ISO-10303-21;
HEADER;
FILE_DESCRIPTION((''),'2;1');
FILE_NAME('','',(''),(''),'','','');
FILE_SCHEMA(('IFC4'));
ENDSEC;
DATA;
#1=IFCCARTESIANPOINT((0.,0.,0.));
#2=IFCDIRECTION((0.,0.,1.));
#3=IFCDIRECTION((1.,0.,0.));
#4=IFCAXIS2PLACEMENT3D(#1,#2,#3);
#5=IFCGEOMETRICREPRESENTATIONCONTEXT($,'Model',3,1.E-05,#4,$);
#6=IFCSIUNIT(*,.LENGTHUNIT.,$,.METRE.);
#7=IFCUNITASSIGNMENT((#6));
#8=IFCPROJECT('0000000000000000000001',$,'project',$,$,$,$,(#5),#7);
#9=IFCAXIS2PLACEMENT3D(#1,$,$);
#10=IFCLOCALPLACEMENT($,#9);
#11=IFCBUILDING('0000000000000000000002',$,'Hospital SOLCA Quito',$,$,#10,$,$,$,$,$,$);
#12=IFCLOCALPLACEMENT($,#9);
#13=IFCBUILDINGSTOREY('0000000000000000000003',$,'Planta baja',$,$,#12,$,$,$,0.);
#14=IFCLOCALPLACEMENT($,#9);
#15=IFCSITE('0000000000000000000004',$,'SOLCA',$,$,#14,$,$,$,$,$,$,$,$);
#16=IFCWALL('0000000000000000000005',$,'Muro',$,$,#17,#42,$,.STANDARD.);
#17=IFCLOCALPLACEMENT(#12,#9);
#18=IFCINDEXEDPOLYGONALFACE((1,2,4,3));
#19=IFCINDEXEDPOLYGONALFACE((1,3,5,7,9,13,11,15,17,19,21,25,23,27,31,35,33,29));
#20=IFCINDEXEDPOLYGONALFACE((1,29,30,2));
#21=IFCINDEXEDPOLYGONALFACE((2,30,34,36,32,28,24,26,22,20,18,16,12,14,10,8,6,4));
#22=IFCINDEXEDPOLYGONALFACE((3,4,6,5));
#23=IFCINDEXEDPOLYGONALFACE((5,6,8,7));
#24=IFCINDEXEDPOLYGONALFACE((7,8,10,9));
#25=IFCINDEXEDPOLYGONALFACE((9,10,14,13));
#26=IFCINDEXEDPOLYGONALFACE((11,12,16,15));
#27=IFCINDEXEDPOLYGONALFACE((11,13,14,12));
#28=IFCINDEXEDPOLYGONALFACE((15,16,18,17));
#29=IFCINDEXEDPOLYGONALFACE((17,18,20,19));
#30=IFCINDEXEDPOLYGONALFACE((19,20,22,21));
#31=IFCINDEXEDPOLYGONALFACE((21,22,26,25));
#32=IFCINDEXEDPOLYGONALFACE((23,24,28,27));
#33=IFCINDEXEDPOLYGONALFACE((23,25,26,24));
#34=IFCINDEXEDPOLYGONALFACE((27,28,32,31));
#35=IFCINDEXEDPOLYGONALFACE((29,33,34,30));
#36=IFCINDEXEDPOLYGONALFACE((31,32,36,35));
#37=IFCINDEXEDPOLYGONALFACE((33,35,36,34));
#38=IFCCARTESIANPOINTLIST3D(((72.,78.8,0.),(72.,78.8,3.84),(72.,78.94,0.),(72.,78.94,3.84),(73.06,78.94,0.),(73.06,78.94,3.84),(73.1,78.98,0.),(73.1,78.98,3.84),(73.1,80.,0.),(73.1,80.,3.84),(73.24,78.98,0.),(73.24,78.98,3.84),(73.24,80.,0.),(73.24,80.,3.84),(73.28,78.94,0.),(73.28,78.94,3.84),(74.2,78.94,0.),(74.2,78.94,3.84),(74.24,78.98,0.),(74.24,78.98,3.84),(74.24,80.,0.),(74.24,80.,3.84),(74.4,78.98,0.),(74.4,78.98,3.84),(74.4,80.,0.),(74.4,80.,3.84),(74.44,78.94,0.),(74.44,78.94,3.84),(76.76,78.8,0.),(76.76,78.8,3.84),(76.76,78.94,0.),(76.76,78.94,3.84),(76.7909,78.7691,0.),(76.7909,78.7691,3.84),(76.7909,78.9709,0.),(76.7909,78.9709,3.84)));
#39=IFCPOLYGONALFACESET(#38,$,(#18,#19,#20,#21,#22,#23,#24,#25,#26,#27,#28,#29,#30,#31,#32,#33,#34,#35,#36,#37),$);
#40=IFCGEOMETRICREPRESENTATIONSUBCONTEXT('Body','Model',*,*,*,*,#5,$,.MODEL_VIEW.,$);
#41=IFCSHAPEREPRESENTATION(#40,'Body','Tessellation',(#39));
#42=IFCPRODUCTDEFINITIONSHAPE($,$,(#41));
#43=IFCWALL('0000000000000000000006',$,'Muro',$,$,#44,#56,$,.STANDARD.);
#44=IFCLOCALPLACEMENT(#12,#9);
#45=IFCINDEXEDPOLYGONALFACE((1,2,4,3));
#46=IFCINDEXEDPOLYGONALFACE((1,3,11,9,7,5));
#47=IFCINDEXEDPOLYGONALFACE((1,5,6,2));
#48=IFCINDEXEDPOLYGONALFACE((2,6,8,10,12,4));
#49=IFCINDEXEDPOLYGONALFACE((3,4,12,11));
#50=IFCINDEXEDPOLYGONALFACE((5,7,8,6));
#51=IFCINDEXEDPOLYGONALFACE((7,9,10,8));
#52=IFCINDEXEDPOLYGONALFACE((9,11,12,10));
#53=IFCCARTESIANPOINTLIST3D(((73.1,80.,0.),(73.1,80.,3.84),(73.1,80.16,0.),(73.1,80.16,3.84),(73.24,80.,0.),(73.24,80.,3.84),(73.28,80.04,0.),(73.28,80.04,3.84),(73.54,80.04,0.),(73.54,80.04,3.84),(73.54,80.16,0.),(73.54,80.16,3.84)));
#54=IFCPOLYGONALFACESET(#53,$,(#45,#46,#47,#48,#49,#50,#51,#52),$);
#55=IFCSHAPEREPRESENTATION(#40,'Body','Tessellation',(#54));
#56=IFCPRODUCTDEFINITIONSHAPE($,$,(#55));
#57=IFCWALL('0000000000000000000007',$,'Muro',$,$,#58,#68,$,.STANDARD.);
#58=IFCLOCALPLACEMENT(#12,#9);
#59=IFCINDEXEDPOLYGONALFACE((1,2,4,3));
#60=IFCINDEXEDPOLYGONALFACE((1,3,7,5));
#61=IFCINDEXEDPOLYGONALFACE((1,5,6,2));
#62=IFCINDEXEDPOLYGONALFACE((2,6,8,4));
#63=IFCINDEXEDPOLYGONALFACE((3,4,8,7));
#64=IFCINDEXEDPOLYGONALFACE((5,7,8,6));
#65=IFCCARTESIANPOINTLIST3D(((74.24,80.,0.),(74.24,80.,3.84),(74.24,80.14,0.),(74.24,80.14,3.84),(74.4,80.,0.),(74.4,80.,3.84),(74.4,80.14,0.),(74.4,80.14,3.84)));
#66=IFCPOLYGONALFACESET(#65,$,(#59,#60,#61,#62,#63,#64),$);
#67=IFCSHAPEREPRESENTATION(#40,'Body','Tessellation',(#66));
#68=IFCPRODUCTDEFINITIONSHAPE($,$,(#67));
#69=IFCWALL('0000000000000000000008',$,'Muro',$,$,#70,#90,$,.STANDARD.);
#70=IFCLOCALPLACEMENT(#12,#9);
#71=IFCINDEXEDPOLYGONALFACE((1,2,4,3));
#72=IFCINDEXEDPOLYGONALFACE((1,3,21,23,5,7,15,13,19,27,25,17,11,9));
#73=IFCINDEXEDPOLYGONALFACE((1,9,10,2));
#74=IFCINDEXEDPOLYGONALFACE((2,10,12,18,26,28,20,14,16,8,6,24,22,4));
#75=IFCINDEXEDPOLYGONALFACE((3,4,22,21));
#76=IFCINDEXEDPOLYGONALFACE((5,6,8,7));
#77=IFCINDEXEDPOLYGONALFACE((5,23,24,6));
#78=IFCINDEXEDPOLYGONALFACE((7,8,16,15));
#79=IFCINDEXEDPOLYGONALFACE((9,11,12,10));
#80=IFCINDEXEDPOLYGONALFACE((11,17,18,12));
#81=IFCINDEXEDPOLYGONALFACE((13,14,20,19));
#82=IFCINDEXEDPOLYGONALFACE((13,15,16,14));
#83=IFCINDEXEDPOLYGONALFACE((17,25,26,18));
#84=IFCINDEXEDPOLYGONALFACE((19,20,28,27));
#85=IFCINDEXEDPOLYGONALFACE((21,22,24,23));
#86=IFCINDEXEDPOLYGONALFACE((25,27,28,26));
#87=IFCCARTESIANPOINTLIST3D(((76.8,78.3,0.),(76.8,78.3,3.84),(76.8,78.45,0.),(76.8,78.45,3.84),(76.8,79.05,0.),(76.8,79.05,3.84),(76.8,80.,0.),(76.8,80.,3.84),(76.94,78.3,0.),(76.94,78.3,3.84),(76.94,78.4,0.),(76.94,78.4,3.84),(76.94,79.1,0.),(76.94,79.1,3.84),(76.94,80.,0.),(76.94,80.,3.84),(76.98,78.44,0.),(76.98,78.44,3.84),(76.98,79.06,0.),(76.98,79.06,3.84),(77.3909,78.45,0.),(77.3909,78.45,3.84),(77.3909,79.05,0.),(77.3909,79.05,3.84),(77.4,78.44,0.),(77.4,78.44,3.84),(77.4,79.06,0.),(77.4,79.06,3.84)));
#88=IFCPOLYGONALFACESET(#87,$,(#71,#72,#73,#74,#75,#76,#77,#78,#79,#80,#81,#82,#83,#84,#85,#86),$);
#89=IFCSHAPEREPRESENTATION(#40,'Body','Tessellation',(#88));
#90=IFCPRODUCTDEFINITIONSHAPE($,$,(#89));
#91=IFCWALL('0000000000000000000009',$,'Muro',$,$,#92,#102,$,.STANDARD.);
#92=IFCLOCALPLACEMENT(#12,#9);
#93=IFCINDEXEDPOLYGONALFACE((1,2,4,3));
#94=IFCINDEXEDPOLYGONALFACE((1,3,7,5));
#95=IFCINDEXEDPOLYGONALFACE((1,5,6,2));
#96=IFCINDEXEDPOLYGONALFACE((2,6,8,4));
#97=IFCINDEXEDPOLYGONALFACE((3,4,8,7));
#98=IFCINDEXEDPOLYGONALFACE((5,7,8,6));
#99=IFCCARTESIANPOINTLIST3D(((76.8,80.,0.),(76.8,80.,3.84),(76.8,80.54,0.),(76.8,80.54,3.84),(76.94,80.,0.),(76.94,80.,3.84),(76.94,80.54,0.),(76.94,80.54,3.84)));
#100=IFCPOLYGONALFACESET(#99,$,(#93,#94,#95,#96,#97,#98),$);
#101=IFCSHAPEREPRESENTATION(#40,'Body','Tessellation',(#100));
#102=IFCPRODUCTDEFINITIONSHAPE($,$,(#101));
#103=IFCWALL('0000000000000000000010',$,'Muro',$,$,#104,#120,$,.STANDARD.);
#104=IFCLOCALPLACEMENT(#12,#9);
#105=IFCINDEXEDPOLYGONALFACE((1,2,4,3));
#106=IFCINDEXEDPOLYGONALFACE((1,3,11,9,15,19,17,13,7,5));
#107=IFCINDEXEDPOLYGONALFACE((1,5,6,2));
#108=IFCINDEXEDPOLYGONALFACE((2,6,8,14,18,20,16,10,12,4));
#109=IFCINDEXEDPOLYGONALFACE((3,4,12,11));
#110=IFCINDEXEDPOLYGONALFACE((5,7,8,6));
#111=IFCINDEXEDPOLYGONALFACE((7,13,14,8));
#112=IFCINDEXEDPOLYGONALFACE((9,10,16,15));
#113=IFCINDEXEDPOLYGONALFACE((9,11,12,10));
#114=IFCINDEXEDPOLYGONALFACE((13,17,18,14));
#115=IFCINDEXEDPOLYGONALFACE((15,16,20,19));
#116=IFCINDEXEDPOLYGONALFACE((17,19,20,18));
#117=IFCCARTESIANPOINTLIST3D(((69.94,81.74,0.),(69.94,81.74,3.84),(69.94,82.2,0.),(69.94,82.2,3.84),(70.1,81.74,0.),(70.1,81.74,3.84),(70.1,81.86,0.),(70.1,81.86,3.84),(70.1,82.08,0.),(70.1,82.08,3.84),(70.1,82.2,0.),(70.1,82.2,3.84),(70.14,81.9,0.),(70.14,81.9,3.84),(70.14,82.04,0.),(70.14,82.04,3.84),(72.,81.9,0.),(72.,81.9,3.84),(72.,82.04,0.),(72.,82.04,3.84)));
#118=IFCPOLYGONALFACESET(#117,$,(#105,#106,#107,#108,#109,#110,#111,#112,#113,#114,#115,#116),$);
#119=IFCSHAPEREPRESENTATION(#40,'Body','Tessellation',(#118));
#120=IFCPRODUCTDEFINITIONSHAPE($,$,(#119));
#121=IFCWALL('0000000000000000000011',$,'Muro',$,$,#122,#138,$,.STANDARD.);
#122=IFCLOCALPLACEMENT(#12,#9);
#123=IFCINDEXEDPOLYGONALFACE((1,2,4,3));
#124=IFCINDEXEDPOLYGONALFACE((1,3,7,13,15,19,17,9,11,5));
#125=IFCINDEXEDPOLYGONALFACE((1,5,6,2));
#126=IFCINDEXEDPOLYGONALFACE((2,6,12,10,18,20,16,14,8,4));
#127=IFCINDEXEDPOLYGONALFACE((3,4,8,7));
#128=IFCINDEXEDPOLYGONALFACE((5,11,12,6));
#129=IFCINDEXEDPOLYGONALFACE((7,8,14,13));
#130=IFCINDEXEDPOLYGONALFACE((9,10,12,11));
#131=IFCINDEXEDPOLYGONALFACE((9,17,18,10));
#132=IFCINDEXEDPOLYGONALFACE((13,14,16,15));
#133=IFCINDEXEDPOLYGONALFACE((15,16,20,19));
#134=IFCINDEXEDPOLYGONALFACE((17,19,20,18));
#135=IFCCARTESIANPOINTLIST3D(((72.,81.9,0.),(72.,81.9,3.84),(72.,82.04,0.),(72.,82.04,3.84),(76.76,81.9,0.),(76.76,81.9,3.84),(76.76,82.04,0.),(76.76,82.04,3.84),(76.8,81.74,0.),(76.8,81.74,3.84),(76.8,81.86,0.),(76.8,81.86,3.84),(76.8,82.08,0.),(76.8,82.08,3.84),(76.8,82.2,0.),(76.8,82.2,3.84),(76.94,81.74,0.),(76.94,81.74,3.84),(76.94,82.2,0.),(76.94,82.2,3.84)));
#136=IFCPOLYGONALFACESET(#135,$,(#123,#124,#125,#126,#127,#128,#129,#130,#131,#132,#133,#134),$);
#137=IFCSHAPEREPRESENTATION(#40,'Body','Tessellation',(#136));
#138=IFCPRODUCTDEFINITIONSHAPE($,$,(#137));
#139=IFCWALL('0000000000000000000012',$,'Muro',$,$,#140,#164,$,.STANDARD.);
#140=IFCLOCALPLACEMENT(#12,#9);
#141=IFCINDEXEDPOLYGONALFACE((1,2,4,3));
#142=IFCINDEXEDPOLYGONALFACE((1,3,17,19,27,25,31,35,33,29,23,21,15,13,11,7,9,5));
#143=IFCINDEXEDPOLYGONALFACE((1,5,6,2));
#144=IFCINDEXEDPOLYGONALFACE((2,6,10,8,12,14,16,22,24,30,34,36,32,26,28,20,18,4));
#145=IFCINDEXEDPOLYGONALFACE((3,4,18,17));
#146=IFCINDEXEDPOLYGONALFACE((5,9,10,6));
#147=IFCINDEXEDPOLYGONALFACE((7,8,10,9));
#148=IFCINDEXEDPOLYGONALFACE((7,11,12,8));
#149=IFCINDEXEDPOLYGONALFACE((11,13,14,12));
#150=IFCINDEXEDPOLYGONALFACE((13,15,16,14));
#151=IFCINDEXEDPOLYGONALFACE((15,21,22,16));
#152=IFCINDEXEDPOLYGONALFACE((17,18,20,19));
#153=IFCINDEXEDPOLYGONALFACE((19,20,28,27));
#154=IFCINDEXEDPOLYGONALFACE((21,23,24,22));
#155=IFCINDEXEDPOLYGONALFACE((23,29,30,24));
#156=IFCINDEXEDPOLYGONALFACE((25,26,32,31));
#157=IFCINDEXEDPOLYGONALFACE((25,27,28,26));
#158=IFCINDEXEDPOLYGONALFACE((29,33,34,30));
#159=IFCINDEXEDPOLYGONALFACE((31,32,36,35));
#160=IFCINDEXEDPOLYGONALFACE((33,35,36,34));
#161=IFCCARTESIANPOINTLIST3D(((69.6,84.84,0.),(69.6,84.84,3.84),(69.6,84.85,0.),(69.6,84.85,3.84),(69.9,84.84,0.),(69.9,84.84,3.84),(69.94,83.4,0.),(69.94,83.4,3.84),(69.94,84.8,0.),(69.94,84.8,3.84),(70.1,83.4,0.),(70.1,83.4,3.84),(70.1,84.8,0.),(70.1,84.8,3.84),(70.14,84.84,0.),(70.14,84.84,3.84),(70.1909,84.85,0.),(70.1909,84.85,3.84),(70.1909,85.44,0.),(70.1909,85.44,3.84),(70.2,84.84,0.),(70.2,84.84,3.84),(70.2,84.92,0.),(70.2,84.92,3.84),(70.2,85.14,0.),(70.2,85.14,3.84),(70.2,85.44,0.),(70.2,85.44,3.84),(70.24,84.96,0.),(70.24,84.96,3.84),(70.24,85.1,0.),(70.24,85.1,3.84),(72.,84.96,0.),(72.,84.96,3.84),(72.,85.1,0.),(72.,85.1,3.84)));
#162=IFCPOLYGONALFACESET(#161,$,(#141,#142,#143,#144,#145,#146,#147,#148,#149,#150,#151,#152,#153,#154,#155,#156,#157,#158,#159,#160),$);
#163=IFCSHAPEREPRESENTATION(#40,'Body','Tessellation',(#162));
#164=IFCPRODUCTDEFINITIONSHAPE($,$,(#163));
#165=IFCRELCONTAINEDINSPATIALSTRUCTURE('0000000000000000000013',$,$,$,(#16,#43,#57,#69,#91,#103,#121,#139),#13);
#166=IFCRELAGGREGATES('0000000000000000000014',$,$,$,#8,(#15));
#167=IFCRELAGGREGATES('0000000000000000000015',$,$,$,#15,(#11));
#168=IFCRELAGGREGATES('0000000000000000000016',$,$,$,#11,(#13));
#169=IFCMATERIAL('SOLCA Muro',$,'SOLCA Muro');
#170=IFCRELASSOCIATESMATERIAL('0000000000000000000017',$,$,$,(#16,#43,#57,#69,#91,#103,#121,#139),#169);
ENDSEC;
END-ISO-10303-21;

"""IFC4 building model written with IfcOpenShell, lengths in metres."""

from ifc_helpers import new_model, si_unit, origin, origin_with_axes, place, context, subcontext, project, spatial, polyline, outline, extrude, material, element, save


model = new_model("IFC4")

# Units and contexts
model_context = context("Model", 3, precision=1e-05, world=origin_with_axes())
body_context = subcontext(model_context, "Body", "Model", "MODEL_VIEW")
ifc_project = project(units=[si_unit("LENGTHUNIT", "METRE")], contexts=[model_context])

# Site, building, storey
site_placement = place(None, origin())
site = spatial("IfcSite", under=ifc_project, at=site_placement, Name="SOLCA")
building_placement = place(None, origin())
building = spatial("IfcBuilding", under=site, at=building_placement, Name="Hospital SOLCA Quito")
storey_placement = place(None, origin())
storey = spatial("IfcBuildingStorey", under=building, at=storey_placement, Name="Planta baja", Elevation=0.0)

# Walls
ifc_material = material(Name="SOLCA Muro", Category="SOLCA Muro")
wall_1_placement = place(storey_placement, origin_with_axes())
element("IfcWall", 1, at=wall_1_placement, inside=storey, material=ifc_material, Name="Muro", PredefinedType="STANDARD", context=body_context, shape_type="SweptSolid", body=[
    extrude(outline(polyline([(76.76, 78.94), (76.7909, 78.9709), (76.7909, 78.7691), (76.76, 78.8), (72.0, 78.8), (72.0, 78.94), (73.06, 78.94), (73.1, 78.98), (73.1, 80.0), (73.24, 80.0), (73.24, 78.98), (73.28, 78.94), (74.2, 78.94), (74.24, 78.98), (74.24, 80.0), (74.4, 80.0), (74.4, 78.98), (74.44, 78.94), (76.76, 78.94)])), origin_with_axes(), (0.0, 0.0, 1.0), 3.84),
])
wall_2_placement = place(storey_placement, origin_with_axes())
element("IfcWall", 2, at=wall_2_placement, inside=storey, material=ifc_material, Name="Muro", PredefinedType="STANDARD", context=body_context, shape_type="SweptSolid", body=[
    extrude(outline(polyline([(73.1, 80.16), (73.54, 80.16), (73.54, 80.04), (73.28, 80.04), (73.24, 80.0), (73.1, 80.0), (73.1, 80.16)])), origin_with_axes(), (0.0, 0.0, 1.0), 3.84),
])
wall_3_placement = place(storey_placement, origin_with_axes())
element("IfcWall", 3, at=wall_3_placement, inside=storey, material=ifc_material, Name="Muro", PredefinedType="STANDARD", context=body_context, shape_type="SweptSolid", body=[
    extrude(outline(polyline([(74.24, 80.14), (74.4, 80.14), (74.4, 80.0), (74.24, 80.0), (74.24, 80.14)])), origin_with_axes(), (0.0, 0.0, 1.0), 3.84),
])
wall_4_placement = place(storey_placement, origin_with_axes())
element("IfcWall", 4, at=wall_4_placement, inside=storey, material=ifc_material, Name="Muro", PredefinedType="STANDARD", context=body_context, shape_type="SweptSolid", body=[
    extrude(outline(polyline([(77.3909, 78.45), (77.3909, 79.05), (76.8, 79.05), (76.8, 80.0), (76.94, 80.0), (76.94, 79.1), (76.98, 79.06), (77.4, 79.06), (77.4, 78.44), (76.98, 78.44), (76.94, 78.4), (76.94, 78.3), (76.8, 78.3), (76.8, 78.45), (77.3909, 78.45)])), origin_with_axes(), (0.0, 0.0, 1.0), 3.84),
])
wall_5_placement = place(storey_placement, origin_with_axes())
element("IfcWall", 5, at=wall_5_placement, inside=storey, material=ifc_material, Name="Muro", PredefinedType="STANDARD", context=body_context, shape_type="SweptSolid", body=[
    extrude(outline(polyline([(76.8, 80.54), (76.94, 80.54), (76.94, 80.0), (76.8, 80.0), (76.8, 80.54)])), origin_with_axes(), (0.0, 0.0, 1.0), 3.84),
])
wall_6_placement = place(storey_placement, origin_with_axes())
element("IfcWall", 6, at=wall_6_placement, inside=storey, material=ifc_material, Name="Muro", PredefinedType="STANDARD", context=body_context, shape_type="SweptSolid", body=[
    extrude(outline(polyline([(70.14, 82.04), (72.0, 82.04), (72.0, 81.9), (70.14, 81.9), (70.1, 81.86), (70.1, 81.74), (69.94, 81.74), (69.94, 82.2), (70.1, 82.2), (70.1, 82.08), (70.14, 82.04)])), origin_with_axes(), (0.0, 0.0, 1.0), 3.84),
])
wall_7_placement = place(storey_placement, origin_with_axes())
element("IfcWall", 7, at=wall_7_placement, inside=storey, material=ifc_material, Name="Muro", PredefinedType="STANDARD", context=body_context, shape_type="SweptSolid", body=[
    extrude(outline(polyline([(76.76, 82.04), (76.8, 82.08), (76.8, 82.2), (76.94, 82.2), (76.94, 81.74), (76.8, 81.74), (76.8, 81.86), (76.76, 81.9), (72.0, 81.9), (72.0, 82.04), (76.76, 82.04)])), origin_with_axes(), (0.0, 0.0, 1.0), 3.84),
])
wall_8_placement = place(storey_placement, origin_with_axes())
element("IfcWall", 8, at=wall_8_placement, inside=storey, material=ifc_material, Name="Muro", PredefinedType="STANDARD", context=body_context, shape_type="SweptSolid", body=[
    extrude(outline(polyline([(70.24, 84.96), (70.2, 84.92), (70.2, 84.84), (70.14, 84.84), (70.1, 84.8), (70.1, 83.4), (69.94, 83.4), (69.94, 84.8), (69.9, 84.84), (69.6, 84.84), (69.6, 84.85), (70.1909, 84.85), (70.1909, 85.44), (70.2, 85.44), (70.2, 85.14), (70.24, 85.1), (72.0, 85.1), (72.0, 84.96), (70.24, 84.96)])), origin_with_axes(), (0.0, 0.0, 1.0), 3.84),
])

save(model, "model.ifc")
